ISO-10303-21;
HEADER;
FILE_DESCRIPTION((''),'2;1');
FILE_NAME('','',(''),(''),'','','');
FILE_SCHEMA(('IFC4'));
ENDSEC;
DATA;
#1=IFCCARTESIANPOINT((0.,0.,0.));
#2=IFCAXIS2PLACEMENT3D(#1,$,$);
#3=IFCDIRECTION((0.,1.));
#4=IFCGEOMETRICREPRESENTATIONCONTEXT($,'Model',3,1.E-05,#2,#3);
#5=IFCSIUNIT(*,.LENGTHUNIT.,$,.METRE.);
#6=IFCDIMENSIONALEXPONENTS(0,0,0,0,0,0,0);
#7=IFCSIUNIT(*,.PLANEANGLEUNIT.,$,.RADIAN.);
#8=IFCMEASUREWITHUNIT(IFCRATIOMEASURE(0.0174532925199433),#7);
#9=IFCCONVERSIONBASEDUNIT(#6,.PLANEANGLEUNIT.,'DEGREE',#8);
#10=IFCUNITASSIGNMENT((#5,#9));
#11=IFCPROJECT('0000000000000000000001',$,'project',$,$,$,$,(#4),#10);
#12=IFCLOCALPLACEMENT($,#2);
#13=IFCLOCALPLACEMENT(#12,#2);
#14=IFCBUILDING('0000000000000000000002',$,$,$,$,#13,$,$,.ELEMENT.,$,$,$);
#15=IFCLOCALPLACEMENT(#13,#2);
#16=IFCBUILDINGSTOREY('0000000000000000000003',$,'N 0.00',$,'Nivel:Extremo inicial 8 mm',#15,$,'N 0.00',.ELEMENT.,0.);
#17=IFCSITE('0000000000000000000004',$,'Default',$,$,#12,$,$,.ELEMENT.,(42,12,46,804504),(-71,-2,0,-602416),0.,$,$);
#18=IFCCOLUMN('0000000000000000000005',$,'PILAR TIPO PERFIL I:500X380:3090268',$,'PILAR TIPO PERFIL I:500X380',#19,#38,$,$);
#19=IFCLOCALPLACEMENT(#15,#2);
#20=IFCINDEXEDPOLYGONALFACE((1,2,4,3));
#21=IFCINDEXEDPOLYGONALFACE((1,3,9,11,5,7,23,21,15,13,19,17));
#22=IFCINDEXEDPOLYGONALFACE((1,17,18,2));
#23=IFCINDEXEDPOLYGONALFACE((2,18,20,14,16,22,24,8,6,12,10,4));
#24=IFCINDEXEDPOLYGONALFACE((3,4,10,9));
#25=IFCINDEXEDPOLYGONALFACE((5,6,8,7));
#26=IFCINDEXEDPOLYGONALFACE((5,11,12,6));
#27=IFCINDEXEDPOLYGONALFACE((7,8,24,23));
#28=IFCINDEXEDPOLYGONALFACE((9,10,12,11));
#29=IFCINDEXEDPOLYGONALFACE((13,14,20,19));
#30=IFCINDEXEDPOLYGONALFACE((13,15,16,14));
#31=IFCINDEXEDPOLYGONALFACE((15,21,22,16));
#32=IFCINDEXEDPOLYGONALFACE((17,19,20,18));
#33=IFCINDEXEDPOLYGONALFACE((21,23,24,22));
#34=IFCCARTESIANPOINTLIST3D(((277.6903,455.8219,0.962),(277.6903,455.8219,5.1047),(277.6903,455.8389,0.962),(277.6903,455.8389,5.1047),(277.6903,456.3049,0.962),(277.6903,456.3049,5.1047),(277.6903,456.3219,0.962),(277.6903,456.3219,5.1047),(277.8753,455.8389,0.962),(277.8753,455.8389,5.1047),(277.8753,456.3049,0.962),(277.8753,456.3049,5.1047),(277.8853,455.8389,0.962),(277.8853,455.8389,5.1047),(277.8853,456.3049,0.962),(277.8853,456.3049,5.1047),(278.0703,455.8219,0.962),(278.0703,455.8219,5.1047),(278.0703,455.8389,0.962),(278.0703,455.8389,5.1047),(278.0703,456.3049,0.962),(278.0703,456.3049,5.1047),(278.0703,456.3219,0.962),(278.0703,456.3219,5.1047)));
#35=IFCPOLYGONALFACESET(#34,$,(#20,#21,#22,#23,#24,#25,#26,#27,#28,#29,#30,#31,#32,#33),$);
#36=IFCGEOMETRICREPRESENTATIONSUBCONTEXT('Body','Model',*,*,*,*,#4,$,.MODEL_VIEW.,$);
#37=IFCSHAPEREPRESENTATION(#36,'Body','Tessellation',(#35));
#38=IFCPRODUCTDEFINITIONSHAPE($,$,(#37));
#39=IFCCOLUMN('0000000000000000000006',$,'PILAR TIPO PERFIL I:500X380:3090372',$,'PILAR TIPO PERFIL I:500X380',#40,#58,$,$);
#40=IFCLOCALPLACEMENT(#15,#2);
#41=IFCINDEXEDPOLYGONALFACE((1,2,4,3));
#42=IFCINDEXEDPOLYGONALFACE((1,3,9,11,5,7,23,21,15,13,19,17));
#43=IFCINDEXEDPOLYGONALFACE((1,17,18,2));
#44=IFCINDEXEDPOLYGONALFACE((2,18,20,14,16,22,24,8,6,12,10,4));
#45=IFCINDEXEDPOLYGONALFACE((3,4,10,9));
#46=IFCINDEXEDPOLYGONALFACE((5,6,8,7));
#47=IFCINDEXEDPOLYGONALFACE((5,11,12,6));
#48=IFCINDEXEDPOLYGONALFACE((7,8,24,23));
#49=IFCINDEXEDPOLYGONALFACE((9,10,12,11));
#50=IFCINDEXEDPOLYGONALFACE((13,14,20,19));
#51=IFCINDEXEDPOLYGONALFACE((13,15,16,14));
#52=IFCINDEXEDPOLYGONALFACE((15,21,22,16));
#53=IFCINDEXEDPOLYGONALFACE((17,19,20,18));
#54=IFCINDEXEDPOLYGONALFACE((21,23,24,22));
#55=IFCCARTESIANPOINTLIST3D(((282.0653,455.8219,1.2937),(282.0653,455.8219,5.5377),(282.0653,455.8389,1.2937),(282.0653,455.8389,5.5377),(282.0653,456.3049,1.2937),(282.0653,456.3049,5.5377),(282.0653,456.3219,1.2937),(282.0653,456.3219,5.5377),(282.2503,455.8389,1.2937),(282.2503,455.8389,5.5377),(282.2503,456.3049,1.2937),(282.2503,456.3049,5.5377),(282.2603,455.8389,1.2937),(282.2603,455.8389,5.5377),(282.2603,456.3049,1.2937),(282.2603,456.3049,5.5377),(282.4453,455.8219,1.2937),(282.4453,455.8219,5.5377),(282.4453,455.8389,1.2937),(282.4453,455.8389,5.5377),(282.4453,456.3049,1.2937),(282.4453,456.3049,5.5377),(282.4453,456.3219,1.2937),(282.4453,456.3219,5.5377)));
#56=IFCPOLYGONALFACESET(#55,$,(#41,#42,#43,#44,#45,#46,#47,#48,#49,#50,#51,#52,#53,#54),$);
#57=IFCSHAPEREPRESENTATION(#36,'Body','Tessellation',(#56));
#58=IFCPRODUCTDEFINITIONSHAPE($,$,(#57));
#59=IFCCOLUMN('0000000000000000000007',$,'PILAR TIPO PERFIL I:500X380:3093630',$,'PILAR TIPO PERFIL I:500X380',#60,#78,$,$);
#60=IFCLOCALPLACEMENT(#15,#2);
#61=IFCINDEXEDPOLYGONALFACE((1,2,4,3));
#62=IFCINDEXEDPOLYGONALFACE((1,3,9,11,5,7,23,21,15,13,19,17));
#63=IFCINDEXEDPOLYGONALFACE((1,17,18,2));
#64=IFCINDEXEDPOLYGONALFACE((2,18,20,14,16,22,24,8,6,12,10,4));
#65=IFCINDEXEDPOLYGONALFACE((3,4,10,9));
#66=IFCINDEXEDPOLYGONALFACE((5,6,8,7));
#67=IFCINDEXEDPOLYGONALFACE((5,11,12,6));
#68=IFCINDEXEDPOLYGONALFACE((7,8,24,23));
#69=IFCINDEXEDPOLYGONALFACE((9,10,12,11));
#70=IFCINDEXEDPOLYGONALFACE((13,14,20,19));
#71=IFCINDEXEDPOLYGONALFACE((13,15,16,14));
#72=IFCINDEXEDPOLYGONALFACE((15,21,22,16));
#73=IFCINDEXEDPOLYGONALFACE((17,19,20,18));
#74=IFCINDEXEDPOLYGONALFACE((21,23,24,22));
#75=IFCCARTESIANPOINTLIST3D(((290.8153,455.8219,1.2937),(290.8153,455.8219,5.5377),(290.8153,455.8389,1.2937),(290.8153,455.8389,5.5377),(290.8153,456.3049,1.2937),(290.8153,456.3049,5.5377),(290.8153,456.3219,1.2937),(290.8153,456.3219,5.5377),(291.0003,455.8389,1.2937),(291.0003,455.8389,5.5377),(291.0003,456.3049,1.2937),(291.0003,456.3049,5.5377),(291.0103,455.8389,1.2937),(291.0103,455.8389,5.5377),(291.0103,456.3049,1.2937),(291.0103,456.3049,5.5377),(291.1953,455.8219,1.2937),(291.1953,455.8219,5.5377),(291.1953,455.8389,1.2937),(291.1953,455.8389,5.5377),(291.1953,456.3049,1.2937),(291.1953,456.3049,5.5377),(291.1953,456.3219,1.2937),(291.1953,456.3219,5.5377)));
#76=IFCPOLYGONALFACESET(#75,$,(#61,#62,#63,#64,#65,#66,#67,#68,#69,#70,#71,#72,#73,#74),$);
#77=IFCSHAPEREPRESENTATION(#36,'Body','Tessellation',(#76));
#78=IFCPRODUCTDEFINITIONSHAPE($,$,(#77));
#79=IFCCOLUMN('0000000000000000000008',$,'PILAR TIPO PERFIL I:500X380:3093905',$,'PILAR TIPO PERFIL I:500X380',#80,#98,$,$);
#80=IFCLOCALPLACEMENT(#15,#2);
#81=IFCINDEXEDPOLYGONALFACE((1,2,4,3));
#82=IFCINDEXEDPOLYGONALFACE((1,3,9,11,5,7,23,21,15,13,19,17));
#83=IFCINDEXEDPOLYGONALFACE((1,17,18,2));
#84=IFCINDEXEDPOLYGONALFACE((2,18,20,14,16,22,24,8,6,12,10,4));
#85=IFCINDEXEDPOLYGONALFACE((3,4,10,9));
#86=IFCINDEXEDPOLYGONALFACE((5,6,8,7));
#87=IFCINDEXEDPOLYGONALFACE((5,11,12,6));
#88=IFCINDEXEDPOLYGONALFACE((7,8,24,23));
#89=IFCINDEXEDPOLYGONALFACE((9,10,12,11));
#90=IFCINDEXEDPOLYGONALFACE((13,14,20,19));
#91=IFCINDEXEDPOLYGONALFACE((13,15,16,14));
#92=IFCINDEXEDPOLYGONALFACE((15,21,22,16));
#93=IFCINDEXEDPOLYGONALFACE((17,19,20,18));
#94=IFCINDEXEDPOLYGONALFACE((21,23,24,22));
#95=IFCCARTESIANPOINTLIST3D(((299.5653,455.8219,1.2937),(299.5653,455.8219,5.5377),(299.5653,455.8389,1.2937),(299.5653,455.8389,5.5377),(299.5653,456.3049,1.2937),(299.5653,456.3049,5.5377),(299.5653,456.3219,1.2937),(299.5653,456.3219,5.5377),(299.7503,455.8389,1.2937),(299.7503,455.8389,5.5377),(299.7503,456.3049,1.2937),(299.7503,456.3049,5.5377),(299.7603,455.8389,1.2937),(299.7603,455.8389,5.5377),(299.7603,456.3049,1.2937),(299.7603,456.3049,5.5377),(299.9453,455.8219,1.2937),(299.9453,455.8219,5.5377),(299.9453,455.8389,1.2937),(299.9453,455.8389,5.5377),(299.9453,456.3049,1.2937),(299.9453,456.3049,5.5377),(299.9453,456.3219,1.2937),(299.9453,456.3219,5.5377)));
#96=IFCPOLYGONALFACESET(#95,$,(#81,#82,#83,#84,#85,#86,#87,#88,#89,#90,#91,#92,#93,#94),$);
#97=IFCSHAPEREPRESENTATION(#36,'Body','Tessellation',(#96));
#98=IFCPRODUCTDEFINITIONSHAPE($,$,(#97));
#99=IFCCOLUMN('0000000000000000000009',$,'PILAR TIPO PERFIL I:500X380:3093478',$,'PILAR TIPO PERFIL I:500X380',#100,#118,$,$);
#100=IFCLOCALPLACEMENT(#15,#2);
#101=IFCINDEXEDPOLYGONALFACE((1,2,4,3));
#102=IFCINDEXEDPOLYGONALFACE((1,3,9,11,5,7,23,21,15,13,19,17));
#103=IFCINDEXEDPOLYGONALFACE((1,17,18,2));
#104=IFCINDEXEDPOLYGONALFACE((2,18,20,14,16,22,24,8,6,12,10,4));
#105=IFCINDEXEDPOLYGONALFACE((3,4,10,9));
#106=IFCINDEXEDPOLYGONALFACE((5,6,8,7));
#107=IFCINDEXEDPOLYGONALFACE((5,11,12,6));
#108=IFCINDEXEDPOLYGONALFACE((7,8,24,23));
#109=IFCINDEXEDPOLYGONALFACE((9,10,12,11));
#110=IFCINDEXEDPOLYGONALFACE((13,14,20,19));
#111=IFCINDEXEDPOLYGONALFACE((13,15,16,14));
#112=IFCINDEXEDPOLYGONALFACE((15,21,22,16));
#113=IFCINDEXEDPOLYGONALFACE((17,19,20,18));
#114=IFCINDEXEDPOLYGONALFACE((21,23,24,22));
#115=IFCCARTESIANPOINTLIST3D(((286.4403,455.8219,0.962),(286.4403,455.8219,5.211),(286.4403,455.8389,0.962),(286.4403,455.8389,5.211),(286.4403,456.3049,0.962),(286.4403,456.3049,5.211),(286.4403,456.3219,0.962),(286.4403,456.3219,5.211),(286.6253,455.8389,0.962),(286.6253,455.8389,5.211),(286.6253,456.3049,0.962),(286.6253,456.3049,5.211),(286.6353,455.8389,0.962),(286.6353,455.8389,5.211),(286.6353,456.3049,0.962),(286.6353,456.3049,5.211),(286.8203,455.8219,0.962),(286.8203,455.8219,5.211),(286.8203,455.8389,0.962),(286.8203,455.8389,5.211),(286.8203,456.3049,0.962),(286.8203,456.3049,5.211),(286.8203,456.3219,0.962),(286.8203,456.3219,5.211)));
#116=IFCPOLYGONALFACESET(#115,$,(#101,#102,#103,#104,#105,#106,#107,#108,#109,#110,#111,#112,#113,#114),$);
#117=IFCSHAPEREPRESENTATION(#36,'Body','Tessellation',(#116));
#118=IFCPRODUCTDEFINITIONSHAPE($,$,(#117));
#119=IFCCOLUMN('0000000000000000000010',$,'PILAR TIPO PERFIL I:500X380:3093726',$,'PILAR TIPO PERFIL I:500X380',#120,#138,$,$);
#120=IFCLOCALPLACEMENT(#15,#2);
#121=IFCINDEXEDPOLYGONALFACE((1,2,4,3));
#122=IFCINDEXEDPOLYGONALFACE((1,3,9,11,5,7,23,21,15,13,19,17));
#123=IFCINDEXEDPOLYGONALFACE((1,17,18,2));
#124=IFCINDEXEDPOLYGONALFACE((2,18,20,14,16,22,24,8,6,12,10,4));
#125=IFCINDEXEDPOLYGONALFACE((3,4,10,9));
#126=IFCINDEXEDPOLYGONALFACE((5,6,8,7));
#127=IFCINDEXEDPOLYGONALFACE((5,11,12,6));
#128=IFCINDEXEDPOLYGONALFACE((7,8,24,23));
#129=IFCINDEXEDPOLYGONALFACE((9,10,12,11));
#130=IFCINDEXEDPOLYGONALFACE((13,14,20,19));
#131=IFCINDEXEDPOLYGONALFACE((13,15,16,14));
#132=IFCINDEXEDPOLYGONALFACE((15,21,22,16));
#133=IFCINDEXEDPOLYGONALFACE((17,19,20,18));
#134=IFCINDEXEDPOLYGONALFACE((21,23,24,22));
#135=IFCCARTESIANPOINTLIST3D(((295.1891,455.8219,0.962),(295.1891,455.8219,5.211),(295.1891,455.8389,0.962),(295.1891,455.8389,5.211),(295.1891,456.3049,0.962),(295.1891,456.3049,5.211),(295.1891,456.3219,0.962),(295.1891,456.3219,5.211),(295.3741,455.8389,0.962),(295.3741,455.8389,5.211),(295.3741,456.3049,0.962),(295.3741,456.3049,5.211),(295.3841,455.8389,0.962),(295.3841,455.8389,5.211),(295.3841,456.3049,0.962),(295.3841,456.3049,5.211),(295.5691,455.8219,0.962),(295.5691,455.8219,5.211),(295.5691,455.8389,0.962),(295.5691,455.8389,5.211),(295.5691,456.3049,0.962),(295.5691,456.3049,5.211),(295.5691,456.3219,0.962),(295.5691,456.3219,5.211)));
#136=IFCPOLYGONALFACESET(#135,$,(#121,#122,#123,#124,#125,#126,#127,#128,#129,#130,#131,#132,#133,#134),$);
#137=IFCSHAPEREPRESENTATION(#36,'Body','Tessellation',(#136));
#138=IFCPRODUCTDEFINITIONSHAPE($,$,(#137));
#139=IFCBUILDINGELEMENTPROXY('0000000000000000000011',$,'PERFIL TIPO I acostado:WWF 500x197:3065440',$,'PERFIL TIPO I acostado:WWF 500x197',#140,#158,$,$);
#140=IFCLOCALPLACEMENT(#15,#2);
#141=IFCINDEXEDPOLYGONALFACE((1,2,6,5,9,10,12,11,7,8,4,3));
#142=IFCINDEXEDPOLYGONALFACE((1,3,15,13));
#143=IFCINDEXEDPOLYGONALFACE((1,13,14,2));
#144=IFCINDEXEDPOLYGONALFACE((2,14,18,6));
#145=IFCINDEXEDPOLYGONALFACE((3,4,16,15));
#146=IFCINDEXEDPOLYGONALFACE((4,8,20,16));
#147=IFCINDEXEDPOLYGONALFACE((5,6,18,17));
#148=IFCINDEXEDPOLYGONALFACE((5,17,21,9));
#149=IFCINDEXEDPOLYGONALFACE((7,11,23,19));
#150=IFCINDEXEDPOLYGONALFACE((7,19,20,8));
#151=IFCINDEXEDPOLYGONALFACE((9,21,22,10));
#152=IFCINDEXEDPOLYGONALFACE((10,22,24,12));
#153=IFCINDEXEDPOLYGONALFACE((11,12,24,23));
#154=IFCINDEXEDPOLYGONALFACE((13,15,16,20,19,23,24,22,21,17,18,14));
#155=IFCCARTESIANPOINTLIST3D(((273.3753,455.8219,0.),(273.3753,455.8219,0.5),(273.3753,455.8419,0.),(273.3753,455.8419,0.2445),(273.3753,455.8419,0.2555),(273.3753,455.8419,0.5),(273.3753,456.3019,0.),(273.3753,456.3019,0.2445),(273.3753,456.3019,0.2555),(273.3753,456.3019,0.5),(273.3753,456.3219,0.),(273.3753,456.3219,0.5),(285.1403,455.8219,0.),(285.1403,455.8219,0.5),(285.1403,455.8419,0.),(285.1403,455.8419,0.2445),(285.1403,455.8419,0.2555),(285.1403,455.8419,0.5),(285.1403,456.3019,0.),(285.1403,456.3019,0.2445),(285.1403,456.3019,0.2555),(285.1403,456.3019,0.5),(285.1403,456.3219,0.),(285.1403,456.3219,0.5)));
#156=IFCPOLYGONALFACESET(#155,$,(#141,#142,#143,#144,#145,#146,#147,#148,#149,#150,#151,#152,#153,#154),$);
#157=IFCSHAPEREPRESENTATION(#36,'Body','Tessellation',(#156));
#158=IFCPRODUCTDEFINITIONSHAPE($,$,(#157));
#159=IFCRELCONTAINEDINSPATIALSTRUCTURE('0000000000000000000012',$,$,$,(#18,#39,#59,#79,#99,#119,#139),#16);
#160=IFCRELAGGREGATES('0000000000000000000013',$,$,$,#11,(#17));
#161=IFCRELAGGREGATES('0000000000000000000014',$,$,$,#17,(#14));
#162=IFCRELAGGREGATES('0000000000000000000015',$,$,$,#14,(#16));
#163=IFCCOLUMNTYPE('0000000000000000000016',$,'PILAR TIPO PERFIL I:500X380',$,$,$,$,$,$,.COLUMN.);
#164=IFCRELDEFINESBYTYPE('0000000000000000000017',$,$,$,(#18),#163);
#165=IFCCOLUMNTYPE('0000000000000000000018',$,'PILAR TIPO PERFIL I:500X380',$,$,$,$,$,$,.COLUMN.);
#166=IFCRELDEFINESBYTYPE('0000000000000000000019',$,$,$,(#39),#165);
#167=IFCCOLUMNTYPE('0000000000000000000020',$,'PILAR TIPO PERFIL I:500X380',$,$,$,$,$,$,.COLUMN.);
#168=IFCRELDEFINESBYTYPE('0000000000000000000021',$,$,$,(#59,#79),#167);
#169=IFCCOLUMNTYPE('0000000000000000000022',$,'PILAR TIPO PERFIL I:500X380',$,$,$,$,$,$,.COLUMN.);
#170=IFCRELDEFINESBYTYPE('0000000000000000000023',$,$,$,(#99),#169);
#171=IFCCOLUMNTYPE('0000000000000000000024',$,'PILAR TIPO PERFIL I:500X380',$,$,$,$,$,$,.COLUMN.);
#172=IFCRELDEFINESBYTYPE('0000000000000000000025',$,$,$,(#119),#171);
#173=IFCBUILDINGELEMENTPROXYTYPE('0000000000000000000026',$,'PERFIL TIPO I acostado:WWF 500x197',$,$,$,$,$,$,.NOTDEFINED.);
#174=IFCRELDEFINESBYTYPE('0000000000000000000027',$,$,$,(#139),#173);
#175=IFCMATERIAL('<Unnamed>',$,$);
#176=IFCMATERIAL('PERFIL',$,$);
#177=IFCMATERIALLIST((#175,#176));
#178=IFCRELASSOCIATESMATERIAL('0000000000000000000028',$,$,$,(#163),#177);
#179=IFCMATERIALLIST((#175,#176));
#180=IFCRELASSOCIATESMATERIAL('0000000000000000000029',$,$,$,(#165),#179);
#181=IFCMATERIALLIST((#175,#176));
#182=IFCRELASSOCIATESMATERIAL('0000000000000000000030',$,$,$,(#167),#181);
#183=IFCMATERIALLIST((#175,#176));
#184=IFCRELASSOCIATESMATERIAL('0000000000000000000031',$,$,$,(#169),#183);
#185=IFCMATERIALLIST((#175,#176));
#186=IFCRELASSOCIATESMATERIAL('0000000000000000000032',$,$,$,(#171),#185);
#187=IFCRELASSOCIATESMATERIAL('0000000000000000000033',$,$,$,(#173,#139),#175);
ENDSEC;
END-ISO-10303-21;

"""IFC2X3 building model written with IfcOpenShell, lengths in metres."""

from ifc_helpers import new_model, entity, si_unit, converted_unit, direction, frame, frame_2d, origin, place, context, subcontext, project, spatial, polyline, i_section, outline, extrude, source, transform, mapped, material, material_list, type_object, type_shapes, element, save


model = new_model("IFC2X3")

# Units and contexts
model_context = context("Model", 3, precision=1e-05, world=origin(), true_north=direction((0.0, 1.0)))
body_context = subcontext(model_context, "Body", "Model", "MODEL_VIEW")
ifc_project = project(units=[si_unit("LENGTHUNIT", "METRE"), converted_unit("PLANEANGLEUNIT", "DEGREE", entity("IfcRatioMeasure", 0.0174532925199433), si_unit("PLANEANGLEUNIT", "RADIAN"), dimensions=[0, 0, 0, 0, 0, 0, 0])], contexts=[model_context])

# Site, building, storey
site_placement = place(None, origin())
site = spatial("IfcSite", under=ifc_project, at=site_placement, Name="Default", CompositionType="ELEMENT", RefLatitude=(42, 12, 46, 804504), RefLongitude=(-71, -2, 0, -602416), RefElevation=0.0)
building_placement = place(site_placement, origin())
building = spatial("IfcBuilding", under=site, at=building_placement, CompositionType="ELEMENT")
storey_placement = place(building_placement, origin())
storey = spatial("IfcBuildingStorey", under=building, at=storey_placement, Name="N 0.00", ObjectType="Nivel:Extremo inicial 8 mm", LongName="N 0.00", CompositionType="ELEMENT", Elevation=0.0)

# Columns
ifc_material_1 = material(Name="<Unnamed>")
ifc_material_2 = material(Name="PERFIL")
ifc_material_list_1 = material_list([ifc_material_1, ifc_material_2])
column_type_1 = type_object("IfcColumnType", Name="PILAR TIPO PERFIL I:500X380", PredefinedType="COLUMN", material=ifc_material_list_1)
shared_shape_1 = source(origin(), body_context, "Body", "SweptSolid", [
    extrude(i_section(OverallWidth=0.38, OverallDepth=0.5, WebThickness=0.01, FlangeThickness=0.017, at=frame_2d((0.0, 0.0), x_axis=(1.0, 0.0))), frame((0.0, 0.0, 0.962), z_axis=(0.0, 0.0, 1.0), x_axis=(0.0, -1.0, 0.0)), (0.0, 0.0, 1.0), 4.1427),
])
type_shapes(column_type_1, [shared_shape_1])
column_1_placement = place(storey_placement, frame((277.8803, 456.0719, 0.0), z_axis=(0.0, 0.0, 1.0), x_axis=(0.0, 1.0, 0.0)))
element("IfcColumn", 1, at=column_1_placement, inside=storey, type_object=column_type_1, Name="PILAR TIPO PERFIL I:500X380:3090268", ObjectType="PILAR TIPO PERFIL I:500X380", context=body_context, shape_type="MappedRepresentation", body=[
    mapped(shared_shape_1, transform((0.0, 0.0, 0.0), scale=1.0)),
])
ifc_material_list_2 = material_list([ifc_material_1, ifc_material_2])
column_type_2 = type_object("IfcColumnType", Name="PILAR TIPO PERFIL I:500X380", PredefinedType="COLUMN", material=ifc_material_list_2)
shared_shape_2 = source(origin(), body_context, "Body", "SweptSolid", [
    extrude(i_section(OverallWidth=0.38, OverallDepth=0.5, WebThickness=0.01, FlangeThickness=0.017, at=frame_2d((0.0, 0.0), x_axis=(1.0, 0.0))), frame((0.0, 0.0, 1.2937), z_axis=(0.0, 0.0, 1.0), x_axis=(0.0, -1.0, 0.0)), (0.0, 0.0, 1.0), 4.244),
])
type_shapes(column_type_2, [shared_shape_2])
column_2_placement = place(storey_placement, frame((282.2553, 456.0719, 0.0), z_axis=(0.0, 0.0, 1.0), x_axis=(0.0, 1.0, 0.0)))
element("IfcColumn", 2, at=column_2_placement, inside=storey, type_object=column_type_2, Name="PILAR TIPO PERFIL I:500X380:3090372", ObjectType="PILAR TIPO PERFIL I:500X380", context=body_context, shape_type="MappedRepresentation", body=[
    mapped(shared_shape_2, transform((0.0, 0.0, 0.0), scale=1.0)),
])
ifc_material_list_3 = material_list([ifc_material_1, ifc_material_2])
column_type_3 = type_object("IfcColumnType", Name="PILAR TIPO PERFIL I:500X380", PredefinedType="COLUMN", material=ifc_material_list_3)
shared_shape_3 = source(origin(), body_context, "Body", "SweptSolid", [
    extrude(i_section(OverallWidth=0.38, OverallDepth=0.5, WebThickness=0.01, FlangeThickness=0.017, at=frame_2d((0.0, 0.0), x_axis=(1.0, 0.0))), frame((0.0, 0.0, 1.2937), z_axis=(0.0, 0.0, 1.0), x_axis=(0.0, -1.0, 0.0)), (0.0, 0.0, 1.0), 4.244),
])
type_shapes(column_type_3, [shared_shape_3])
for number, where, z_axis, x_axis, name in (
    (3, (291.0053, 456.0719, 0.0), (0.0, 0.0, 1.0), (0.0, 1.0, 0.0), "PILAR TIPO PERFIL I:500X380:3093630"),
    (4, (299.7553, 456.0719, 0.0), (0.0, 0.0, 1.0), (0.0, 1.0, 0.0), "PILAR TIPO PERFIL I:500X380:3093905"),
):
    element("IfcColumn", number, at=place(storey_placement, frame(where, z_axis=z_axis, x_axis=x_axis)), inside=storey, type_object=column_type_3, Name=name, ObjectType="PILAR TIPO PERFIL I:500X380", context=body_context, shape_type="MappedRepresentation", body=[
        mapped(shared_shape_3, transform((0.0, 0.0, 0.0), scale=1.0)),
    ])
ifc_material_list_4 = material_list([ifc_material_1, ifc_material_2])
column_type_4 = type_object("IfcColumnType", Name="PILAR TIPO PERFIL I:500X380", PredefinedType="COLUMN", material=ifc_material_list_4)
shared_shape_4 = source(origin(), body_context, "Body", "SweptSolid", [
    extrude(i_section(OverallWidth=0.38, OverallDepth=0.5, WebThickness=0.01, FlangeThickness=0.017, at=frame_2d((0.0, 0.0), x_axis=(1.0, 0.0))), frame((0.0, 0.0, 0.962), z_axis=(0.0, 0.0, 1.0), x_axis=(0.0, -1.0, 0.0)), (0.0, 0.0, 1.0), 4.249),
])
type_shapes(column_type_4, [shared_shape_4])
column_3_placement = place(storey_placement, frame((286.6303, 456.0719, 0.0), z_axis=(0.0, 0.0, 1.0), x_axis=(0.0, 1.0, 0.0)))
element("IfcColumn", 5, at=column_3_placement, inside=storey, type_object=column_type_4, Name="PILAR TIPO PERFIL I:500X380:3093478", ObjectType="PILAR TIPO PERFIL I:500X380", context=body_context, shape_type="MappedRepresentation", body=[
    mapped(shared_shape_4, transform((0.0, 0.0, 0.0), scale=1.0)),
])
ifc_material_list_5 = material_list([ifc_material_1, ifc_material_2])
column_type_5 = type_object("IfcColumnType", Name="PILAR TIPO PERFIL I:500X380", PredefinedType="COLUMN", material=ifc_material_list_5)
shared_shape_5 = source(origin(), body_context, "Body", "SweptSolid", [
    extrude(i_section(OverallWidth=0.38, OverallDepth=0.5, WebThickness=0.01, FlangeThickness=0.017, at=frame_2d((0.0, 0.0), x_axis=(1.0, 0.0))), frame((0.0, 0.0, 0.962), z_axis=(0.0, 0.0, 1.0), x_axis=(0.0, -1.0, 0.0)), (0.0, 0.0, 1.0), 4.249),
])
type_shapes(column_type_5, [shared_shape_5])
column_4_placement = place(storey_placement, frame((295.3791, 456.0719, 0.0), z_axis=(0.0, 0.0, 1.0), x_axis=(0.0, 1.0, 0.0)))
element("IfcColumn", 6, at=column_4_placement, inside=storey, type_object=column_type_5, Name="PILAR TIPO PERFIL I:500X380:3093726", ObjectType="PILAR TIPO PERFIL I:500X380", context=body_context, shape_type="MappedRepresentation", body=[
    mapped(shared_shape_5, transform((0.0, 0.0, 0.0), scale=1.0)),
])

# Building element proxy
building_element_proxy_type_1 = type_object("IfcBuildingElementProxyType", Name="PERFIL TIPO I acostado:WWF 500x197", PredefinedType="NOTDEFINED", material=ifc_material_1)
shared_shape_6 = source(origin(), body_context, "Body", "SweptSolid", [
    extrude(outline(polyline([(0.23, -0.25), (0.25, -0.25), (0.25, 0.25), (0.23, 0.25), (0.23, 0.0055), (-0.23, 0.0055), (-0.23, 0.25), (-0.25, 0.25), (-0.25, -0.25), (-0.23, -0.25), (-0.23, -0.0055), (0.23, -0.0055), (0.23, -0.25)])), frame((0.0, 0.0, 0.25), z_axis=(1.0, 0.0, 0.0), x_axis=(0.0, -1.0, 0.0)), (0.0, 0.0, 1.0), 11.765),
])
type_shapes(building_element_proxy_type_1, [shared_shape_6])
proxy_1_placement = place(storey_placement, frame((273.3753, 456.0719, 0.0)))
element("IfcBuildingElementProxy", 7, at=proxy_1_placement, inside=storey, type_object=building_element_proxy_type_1, material=ifc_material_1, Name="PERFIL TIPO I acostado:WWF 500x197:3065440", ObjectType="PERFIL TIPO I acostado:WWF 500x197", context=body_context, shape_type="MappedRepresentation", body=[
    mapped(shared_shape_6, transform((0.0, 0.0, 0.0), scale=1.0)),
])

save(model, "model.ifc")
